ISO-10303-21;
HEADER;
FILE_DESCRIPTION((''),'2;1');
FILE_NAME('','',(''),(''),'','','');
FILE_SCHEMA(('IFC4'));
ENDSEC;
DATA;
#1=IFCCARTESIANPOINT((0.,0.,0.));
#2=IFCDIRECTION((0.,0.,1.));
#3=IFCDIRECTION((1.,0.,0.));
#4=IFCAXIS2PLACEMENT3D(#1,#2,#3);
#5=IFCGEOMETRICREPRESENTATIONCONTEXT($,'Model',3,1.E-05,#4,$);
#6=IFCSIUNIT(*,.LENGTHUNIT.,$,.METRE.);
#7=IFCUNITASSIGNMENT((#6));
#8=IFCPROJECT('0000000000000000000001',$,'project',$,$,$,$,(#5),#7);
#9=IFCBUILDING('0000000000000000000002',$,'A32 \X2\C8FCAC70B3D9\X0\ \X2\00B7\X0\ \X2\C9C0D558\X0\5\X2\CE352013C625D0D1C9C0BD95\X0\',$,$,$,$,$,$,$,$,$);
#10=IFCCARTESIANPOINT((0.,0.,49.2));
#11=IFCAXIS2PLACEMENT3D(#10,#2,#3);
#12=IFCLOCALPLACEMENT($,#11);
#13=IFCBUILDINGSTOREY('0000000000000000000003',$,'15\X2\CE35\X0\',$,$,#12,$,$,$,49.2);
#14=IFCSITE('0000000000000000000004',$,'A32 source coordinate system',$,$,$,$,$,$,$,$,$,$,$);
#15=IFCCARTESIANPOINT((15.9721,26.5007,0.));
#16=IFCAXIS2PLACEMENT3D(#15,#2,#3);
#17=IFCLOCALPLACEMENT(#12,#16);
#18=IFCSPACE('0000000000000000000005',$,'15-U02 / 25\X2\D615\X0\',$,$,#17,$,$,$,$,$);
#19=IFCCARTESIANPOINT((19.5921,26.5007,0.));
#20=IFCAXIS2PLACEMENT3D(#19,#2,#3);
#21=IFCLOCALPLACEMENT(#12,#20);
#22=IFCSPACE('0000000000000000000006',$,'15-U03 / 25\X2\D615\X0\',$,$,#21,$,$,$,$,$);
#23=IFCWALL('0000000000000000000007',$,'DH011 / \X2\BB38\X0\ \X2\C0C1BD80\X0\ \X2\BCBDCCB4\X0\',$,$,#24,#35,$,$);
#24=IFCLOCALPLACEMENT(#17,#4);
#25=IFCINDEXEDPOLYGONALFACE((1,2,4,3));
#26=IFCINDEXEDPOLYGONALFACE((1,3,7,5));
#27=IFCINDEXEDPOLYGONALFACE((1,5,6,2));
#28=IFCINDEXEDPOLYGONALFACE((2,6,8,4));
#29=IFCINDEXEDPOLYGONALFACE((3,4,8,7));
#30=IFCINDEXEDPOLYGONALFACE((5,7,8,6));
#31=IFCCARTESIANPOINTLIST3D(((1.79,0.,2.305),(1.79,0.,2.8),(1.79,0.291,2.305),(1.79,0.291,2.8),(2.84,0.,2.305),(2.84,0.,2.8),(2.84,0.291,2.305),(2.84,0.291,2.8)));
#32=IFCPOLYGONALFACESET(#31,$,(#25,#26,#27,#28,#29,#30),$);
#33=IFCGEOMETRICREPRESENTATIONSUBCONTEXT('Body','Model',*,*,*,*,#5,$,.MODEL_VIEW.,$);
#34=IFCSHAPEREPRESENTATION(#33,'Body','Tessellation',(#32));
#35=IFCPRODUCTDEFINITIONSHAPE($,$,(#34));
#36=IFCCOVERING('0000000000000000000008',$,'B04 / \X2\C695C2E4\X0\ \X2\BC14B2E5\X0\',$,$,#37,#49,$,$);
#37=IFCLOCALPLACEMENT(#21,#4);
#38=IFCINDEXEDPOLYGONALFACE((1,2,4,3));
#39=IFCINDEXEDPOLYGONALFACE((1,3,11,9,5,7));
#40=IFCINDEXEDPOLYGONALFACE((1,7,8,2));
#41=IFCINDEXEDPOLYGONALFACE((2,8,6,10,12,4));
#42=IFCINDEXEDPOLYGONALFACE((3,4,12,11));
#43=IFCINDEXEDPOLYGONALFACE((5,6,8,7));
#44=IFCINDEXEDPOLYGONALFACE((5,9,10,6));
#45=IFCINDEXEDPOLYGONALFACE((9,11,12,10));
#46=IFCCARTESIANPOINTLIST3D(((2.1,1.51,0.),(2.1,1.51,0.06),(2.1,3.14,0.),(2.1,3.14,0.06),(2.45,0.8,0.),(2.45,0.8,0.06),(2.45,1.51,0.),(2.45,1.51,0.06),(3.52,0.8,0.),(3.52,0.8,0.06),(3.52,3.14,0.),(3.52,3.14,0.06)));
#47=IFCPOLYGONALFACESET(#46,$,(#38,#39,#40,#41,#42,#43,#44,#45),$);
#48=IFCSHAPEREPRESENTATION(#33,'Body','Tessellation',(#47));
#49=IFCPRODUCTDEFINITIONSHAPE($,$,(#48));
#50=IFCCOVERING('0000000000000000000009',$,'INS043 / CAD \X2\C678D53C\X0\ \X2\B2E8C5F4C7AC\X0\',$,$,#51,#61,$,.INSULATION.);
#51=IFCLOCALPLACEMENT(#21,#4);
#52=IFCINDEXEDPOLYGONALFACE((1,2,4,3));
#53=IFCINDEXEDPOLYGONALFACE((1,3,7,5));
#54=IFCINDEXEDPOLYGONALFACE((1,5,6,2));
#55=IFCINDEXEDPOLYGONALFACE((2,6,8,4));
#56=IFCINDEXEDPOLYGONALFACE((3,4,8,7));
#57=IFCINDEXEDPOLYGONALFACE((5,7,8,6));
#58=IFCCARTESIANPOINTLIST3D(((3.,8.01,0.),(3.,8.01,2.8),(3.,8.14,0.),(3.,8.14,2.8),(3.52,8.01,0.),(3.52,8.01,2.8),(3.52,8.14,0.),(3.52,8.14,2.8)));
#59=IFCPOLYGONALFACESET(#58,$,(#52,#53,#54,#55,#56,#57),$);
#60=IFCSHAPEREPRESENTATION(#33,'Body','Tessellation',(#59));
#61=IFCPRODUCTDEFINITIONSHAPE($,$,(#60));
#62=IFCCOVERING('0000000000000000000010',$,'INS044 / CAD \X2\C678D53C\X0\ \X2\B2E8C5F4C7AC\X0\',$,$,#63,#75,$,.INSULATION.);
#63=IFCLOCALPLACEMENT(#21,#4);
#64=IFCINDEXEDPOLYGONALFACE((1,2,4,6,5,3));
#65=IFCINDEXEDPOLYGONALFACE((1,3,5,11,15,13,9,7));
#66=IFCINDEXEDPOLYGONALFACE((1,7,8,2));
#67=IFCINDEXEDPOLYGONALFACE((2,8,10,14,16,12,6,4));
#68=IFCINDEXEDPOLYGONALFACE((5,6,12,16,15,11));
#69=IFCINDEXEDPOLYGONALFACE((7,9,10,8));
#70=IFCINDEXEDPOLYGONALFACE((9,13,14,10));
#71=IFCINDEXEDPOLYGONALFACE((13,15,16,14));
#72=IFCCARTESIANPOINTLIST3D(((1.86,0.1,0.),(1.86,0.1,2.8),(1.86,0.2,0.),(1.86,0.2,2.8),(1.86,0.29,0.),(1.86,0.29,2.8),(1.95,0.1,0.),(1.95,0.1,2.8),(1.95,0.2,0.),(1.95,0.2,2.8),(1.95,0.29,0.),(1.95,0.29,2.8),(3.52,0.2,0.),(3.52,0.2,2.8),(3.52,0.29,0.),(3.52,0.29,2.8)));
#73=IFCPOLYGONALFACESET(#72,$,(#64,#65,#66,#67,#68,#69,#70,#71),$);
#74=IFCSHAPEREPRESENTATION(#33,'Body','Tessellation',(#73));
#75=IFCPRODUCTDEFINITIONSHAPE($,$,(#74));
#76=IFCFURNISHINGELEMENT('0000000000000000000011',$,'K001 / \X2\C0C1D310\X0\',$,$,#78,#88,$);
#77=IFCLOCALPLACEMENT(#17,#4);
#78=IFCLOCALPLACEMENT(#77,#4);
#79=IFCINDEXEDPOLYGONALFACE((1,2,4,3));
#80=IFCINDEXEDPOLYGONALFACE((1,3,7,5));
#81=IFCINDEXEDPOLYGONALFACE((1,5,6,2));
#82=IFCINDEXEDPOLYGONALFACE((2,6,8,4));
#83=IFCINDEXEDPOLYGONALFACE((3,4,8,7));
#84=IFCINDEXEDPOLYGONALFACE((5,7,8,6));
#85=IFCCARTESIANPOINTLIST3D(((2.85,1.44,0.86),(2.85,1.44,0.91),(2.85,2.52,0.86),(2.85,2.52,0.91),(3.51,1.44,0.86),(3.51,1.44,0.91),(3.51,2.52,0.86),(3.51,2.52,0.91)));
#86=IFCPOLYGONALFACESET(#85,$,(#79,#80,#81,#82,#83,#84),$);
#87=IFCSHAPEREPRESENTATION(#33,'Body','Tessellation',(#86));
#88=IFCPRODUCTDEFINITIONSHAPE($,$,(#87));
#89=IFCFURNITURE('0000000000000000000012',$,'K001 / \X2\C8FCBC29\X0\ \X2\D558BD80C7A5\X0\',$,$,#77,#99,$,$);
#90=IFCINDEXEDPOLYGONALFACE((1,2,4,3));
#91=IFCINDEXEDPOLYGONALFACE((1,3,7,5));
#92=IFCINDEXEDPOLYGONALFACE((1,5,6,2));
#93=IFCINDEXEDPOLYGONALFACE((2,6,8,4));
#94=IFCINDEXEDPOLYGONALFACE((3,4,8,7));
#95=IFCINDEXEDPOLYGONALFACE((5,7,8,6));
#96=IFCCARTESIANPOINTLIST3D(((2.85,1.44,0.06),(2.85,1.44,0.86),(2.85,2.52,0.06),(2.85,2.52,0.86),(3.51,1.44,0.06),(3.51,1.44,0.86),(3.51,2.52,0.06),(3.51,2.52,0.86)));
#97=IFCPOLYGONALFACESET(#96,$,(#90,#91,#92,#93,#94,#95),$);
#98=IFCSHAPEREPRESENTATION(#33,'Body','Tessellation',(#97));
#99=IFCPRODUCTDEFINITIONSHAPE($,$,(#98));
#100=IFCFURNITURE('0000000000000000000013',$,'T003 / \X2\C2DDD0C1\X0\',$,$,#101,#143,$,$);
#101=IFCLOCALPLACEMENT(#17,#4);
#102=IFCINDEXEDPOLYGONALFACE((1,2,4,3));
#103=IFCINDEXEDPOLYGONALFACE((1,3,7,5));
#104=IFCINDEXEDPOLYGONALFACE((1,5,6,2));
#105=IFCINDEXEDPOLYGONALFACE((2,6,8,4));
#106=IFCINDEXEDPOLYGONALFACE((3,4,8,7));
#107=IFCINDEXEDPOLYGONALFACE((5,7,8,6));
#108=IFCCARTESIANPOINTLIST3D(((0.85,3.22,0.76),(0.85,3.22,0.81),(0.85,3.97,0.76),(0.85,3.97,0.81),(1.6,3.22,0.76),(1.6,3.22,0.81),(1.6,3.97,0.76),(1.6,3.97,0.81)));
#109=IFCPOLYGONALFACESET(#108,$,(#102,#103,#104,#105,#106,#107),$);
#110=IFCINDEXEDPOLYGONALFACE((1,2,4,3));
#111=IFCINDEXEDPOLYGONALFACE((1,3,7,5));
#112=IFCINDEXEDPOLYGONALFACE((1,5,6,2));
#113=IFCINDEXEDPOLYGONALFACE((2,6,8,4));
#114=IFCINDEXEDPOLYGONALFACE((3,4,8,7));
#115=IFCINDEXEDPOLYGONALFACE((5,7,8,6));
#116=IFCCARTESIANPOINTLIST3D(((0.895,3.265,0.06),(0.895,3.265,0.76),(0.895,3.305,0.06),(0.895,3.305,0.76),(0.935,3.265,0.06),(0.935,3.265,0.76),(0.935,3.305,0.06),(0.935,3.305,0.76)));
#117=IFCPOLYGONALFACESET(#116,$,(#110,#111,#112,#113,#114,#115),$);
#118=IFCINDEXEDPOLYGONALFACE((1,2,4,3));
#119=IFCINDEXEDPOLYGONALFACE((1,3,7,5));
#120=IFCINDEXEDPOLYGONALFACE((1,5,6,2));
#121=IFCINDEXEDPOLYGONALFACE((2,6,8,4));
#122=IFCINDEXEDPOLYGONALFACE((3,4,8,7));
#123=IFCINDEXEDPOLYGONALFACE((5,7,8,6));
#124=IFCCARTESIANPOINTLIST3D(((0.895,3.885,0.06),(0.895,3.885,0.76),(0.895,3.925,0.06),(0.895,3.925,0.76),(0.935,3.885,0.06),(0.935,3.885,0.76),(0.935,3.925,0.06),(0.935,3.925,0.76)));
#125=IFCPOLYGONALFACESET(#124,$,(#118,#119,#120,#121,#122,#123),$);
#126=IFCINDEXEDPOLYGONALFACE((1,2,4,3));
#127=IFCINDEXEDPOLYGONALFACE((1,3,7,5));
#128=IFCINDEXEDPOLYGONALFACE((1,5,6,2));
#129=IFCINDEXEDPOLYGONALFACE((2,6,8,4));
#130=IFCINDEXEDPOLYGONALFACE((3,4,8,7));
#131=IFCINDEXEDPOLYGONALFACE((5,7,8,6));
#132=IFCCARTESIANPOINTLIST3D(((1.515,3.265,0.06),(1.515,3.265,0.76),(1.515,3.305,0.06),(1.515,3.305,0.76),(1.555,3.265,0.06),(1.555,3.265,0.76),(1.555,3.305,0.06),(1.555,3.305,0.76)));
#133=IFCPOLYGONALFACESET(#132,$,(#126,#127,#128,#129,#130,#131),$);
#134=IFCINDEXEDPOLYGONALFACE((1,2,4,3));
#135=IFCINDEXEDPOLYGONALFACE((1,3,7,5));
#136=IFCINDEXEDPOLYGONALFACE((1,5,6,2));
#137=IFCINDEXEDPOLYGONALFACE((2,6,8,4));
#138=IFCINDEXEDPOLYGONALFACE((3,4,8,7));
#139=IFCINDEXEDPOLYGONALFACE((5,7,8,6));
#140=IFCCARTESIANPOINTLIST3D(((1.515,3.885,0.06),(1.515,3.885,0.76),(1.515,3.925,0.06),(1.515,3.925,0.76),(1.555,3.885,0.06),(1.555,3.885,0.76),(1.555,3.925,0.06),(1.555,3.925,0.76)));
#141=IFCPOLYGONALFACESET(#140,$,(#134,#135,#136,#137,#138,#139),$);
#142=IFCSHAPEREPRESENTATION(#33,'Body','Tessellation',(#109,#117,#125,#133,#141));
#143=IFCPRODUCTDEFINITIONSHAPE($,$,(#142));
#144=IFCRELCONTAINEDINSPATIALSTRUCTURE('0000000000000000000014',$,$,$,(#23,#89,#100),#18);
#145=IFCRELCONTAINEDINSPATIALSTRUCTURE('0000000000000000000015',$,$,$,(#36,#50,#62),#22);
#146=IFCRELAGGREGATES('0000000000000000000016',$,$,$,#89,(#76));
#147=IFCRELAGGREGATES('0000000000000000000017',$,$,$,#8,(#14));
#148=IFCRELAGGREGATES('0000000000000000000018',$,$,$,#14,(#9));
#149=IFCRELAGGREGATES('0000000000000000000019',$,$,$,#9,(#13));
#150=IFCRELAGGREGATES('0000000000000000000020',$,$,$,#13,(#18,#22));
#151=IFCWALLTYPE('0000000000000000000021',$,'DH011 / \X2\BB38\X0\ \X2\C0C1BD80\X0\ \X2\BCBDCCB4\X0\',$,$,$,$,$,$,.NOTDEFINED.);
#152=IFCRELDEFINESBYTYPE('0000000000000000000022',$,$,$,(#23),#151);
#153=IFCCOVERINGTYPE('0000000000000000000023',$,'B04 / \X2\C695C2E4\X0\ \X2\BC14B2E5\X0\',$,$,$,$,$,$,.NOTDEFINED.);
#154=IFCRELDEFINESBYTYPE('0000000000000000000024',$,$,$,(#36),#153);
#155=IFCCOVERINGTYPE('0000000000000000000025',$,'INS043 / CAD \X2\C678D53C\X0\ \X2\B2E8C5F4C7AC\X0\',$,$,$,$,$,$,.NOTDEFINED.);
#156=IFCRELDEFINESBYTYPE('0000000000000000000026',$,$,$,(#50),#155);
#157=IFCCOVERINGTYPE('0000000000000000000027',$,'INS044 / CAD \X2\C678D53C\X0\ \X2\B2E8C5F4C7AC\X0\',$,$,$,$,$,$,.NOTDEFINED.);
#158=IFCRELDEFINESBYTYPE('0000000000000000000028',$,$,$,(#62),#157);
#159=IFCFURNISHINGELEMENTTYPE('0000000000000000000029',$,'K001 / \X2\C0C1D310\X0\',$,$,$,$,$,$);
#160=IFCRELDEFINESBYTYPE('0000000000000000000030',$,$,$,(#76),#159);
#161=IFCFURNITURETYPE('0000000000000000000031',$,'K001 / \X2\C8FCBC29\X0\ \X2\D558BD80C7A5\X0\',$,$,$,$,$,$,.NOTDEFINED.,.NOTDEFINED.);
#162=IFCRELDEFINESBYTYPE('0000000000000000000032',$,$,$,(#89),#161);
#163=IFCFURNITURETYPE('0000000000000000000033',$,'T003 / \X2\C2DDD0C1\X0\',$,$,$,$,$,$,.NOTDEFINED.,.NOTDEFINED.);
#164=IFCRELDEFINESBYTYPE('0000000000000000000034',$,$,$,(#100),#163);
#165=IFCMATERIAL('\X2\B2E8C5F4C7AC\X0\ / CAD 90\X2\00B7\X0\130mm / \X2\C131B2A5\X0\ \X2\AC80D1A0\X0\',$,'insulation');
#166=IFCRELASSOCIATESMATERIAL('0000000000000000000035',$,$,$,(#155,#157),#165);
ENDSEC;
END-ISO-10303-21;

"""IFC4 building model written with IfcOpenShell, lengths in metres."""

from ifc_helpers import new_model, si_unit, frame, origin, origin_with_axes, place, context, subcontext, project, spatial, polyline, outline, extrude, source, transform, mapped, material, type_object, type_shapes, element, aggregate, save


model = new_model("IFC4")

# Units and contexts
model_context = context("Model", 3, precision=1e-05, world=origin_with_axes())
body_context = subcontext(model_context, "Body", "Model", "MODEL_VIEW")
ifc_project = project(units=[si_unit("LENGTHUNIT", "METRE")], contexts=[model_context])

# Site, building, storey, space
site = spatial("IfcSite", under=ifc_project, Name="A32 source coordinate system")
building = spatial("IfcBuilding", under=site, Name="A32 주거동 · 지하5층–옥탑지붕")
storey_placement = place(None, frame((0.0, 0.0, 49.2), z_axis=(0.0, 0.0, 1.0), x_axis=(1.0, 0.0, 0.0)))
storey = spatial("IfcBuildingStorey", under=building, at=storey_placement, Name="15층", Elevation=49.2)
space_1_placement = place(storey_placement, frame((15.9721, 26.5007, 0.0), z_axis=(0.0, 0.0, 1.0), x_axis=(1.0, 0.0, 0.0)))
space_1 = spatial("IfcSpace", under=storey, at=space_1_placement, Name="15-U02 / 25형")

# Wall
wall_type_1 = type_object("IfcWallType", Name="DH011 / 문 상부 벽체", PredefinedType="NOTDEFINED")
shared_shape_1 = source(origin(), body_context, "Body", "SweptSolid", [
    extrude(outline(polyline([(2.84, 0.0), (1.79, 0.0), (1.79, 0.291), (2.84, 0.291), (2.84, 0.0)])), frame((0.0, 0.0, 2.305)), (0.0, 0.0, 1.0), 0.495),
])
type_shapes(wall_type_1, [shared_shape_1])
wall_1_placement = place(space_1_placement, origin_with_axes())
element("IfcWall", 1, at=wall_1_placement, inside=space_1, type_object=wall_type_1, Name="DH011 / 문 상부 벽체", context=body_context, shape_type="MappedRepresentation", body=[
    mapped(shared_shape_1, transform((0.0, 0.0, 0.0), scale=1.0)),
])

# Shared definitions
space_2_placement = place(storey_placement, frame((19.5921, 26.5007, 0.0), z_axis=(0.0, 0.0, 1.0), x_axis=(1.0, 0.0, 0.0)))
space_2 = spatial("IfcSpace", under=storey, at=space_2_placement, Name="15-U03 / 25형")

# Coverings
covering_type_1 = type_object("IfcCoveringType", Name="B04 / 욕실 바닥", PredefinedType="NOTDEFINED")
shared_shape_2 = source(origin(), body_context, "Body", "SweptSolid", [
    extrude(outline(polyline([(2.1, 1.51), (2.1, 3.14), (3.52, 3.14), (3.52, 0.8), (2.45, 0.8), (2.45, 1.51), (2.1, 1.51)])), origin(), (0.0, 0.0, 1.0), 0.06),
])
type_shapes(covering_type_1, [shared_shape_2])
covering_1_placement = place(space_2_placement, origin_with_axes())
element("IfcCovering", 2, at=covering_1_placement, inside=space_2, type_object=covering_type_1, Name="B04 / 욕실 바닥", context=body_context, shape_type="MappedRepresentation", body=[
    mapped(shared_shape_2, transform((0.0, 0.0, 0.0), scale=1.0)),
])
ifc_material = material(Name="단열재 / CAD 90·130mm / 성능 검토", Category="insulation")
covering_type_2 = type_object("IfcCoveringType", Name="INS043 / CAD 외피 단열재", PredefinedType="NOTDEFINED", material=ifc_material)
shared_shape_3 = source(origin(), body_context, "Body", "SweptSolid", [
    extrude(outline(polyline([(3.52, 8.14), (3.52, 8.01), (3.0, 8.01), (3.0, 8.14), (3.52, 8.14)])), origin(), (0.0, 0.0, 1.0), 2.8),
])
type_shapes(covering_type_2, [shared_shape_3])
covering_2_placement = place(space_2_placement, origin_with_axes())
element("IfcCovering", 3, at=covering_2_placement, inside=space_2, type_object=covering_type_2, Name="INS043 / CAD 외피 단열재", PredefinedType="INSULATION", context=body_context, shape_type="MappedRepresentation", body=[
    mapped(shared_shape_3, transform((0.0, 0.0, 0.0), scale=1.0)),
])
covering_type_3 = type_object("IfcCoveringType", Name="INS044 / CAD 외피 단열재", PredefinedType="NOTDEFINED", material=ifc_material)
shared_shape_4 = source(origin(), body_context, "Body", "SweptSolid", [
    extrude(outline(polyline([(1.86, 0.2), (1.86, 0.29), (1.95, 0.29), (3.52, 0.29), (3.52, 0.2), (1.95, 0.2), (1.95, 0.1), (1.86, 0.1), (1.86, 0.2)])), origin(), (0.0, 0.0, 1.0), 2.8),
])
type_shapes(covering_type_3, [shared_shape_4])
covering_3_placement = place(space_2_placement, origin_with_axes())
element("IfcCovering", 4, at=covering_3_placement, inside=space_2, type_object=covering_type_3, Name="INS044 / CAD 외피 단열재", PredefinedType="INSULATION", context=body_context, shape_type="MappedRepresentation", body=[
    mapped(shared_shape_4, transform((0.0, 0.0, 0.0), scale=1.0)),
])

# Furnishing element
furnishing_element_type_1 = type_object("IfcFurnishingElementType", Name="K001 / 상판")
shared_shape_5 = source(origin(), body_context, "Body", "SweptSolid", [
    extrude(outline(polyline([(2.85, 2.52), (3.51, 2.52), (3.51, 1.44), (2.85, 1.44), (2.85, 2.52)])), frame((0.0, 0.0, 0.86)), (0.0, 0.0, 1.0), 0.05),
])
type_shapes(furnishing_element_type_1, [shared_shape_5])
furniture_1_placement = place(space_1_placement, origin_with_axes())
furnishing_1_placement = place(furniture_1_placement, origin_with_axes())
furnishing_1 = element("IfcFurnishingElement", 5, at=furnishing_1_placement, type_object=furnishing_element_type_1, Name="K001 / 상판", context=body_context, shape_type="MappedRepresentation", body=[
    mapped(shared_shape_5, transform((0.0, 0.0, 0.0), scale=1.0)),
])

# Furniture
furniture_type_1 = type_object("IfcFurnitureType", Name="K001 / 주방 하부장", AssemblyPlace="NOTDEFINED", PredefinedType="NOTDEFINED")
shared_shape_6 = source(origin(), body_context, "Body", "SweptSolid", [
    extrude(outline(polyline([(2.85, 1.44), (2.85, 2.52), (3.51, 2.52), (3.51, 1.44), (2.85, 1.44)])), frame((0.0, 0.0, 0.06)), (0.0, 0.0, 1.0), 0.8),
])
type_shapes(furniture_type_1, [shared_shape_6])
furniture_1 = element("IfcFurniture", 6, at=furniture_1_placement, inside=space_1, type_object=furniture_type_1, Name="K001 / 주방 하부장", context=body_context, shape_type="MappedRepresentation", body=[
    mapped(shared_shape_6, transform((0.0, 0.0, 0.0), scale=1.0)),
])
aggregate(furniture_1, [furnishing_1])
furniture_type_2 = type_object("IfcFurnitureType", Name="T003 / 식탁", AssemblyPlace="NOTDEFINED", PredefinedType="NOTDEFINED")
shared_shape_7 = source(origin(), body_context, "Body", "SweptSolid", [
    extrude(outline(polyline([(1.6, 3.97), (1.6, 3.22), (0.85, 3.22), (0.85, 3.97), (1.6, 3.97)])), frame((0.0, 0.0, 0.76)), (0.0, 0.0, 1.0), 0.05),
    extrude(outline(polyline([(0.895, 3.265), (0.895, 3.305), (0.935, 3.305), (0.935, 3.265), (0.895, 3.265)])), frame((0.0, 0.0, 0.06)), (0.0, 0.0, 1.0), 0.7),
    extrude(outline(polyline([(0.895, 3.885), (0.895, 3.925), (0.935, 3.925), (0.935, 3.885), (0.895, 3.885)])), frame((0.0, 0.0, 0.06)), (0.0, 0.0, 1.0), 0.7),
    extrude(outline(polyline([(1.515, 3.265), (1.515, 3.305), (1.555, 3.305), (1.555, 3.265), (1.515, 3.265)])), frame((0.0, 0.0, 0.06)), (0.0, 0.0, 1.0), 0.7),
    extrude(outline(polyline([(1.515, 3.885), (1.515, 3.925), (1.555, 3.925), (1.555, 3.885), (1.515, 3.885)])), frame((0.0, 0.0, 0.06)), (0.0, 0.0, 1.0), 0.7),
])
type_shapes(furniture_type_2, [shared_shape_7])
furniture_2_placement = place(space_1_placement, origin_with_axes())
element("IfcFurniture", 7, at=furniture_2_placement, inside=space_1, type_object=furniture_type_2, Name="T003 / 식탁", context=body_context, shape_type="MappedRepresentation", body=[
    mapped(shared_shape_7, transform((0.0, 0.0, 0.0), scale=1.0)),
])

save(model, "model.ifc")
